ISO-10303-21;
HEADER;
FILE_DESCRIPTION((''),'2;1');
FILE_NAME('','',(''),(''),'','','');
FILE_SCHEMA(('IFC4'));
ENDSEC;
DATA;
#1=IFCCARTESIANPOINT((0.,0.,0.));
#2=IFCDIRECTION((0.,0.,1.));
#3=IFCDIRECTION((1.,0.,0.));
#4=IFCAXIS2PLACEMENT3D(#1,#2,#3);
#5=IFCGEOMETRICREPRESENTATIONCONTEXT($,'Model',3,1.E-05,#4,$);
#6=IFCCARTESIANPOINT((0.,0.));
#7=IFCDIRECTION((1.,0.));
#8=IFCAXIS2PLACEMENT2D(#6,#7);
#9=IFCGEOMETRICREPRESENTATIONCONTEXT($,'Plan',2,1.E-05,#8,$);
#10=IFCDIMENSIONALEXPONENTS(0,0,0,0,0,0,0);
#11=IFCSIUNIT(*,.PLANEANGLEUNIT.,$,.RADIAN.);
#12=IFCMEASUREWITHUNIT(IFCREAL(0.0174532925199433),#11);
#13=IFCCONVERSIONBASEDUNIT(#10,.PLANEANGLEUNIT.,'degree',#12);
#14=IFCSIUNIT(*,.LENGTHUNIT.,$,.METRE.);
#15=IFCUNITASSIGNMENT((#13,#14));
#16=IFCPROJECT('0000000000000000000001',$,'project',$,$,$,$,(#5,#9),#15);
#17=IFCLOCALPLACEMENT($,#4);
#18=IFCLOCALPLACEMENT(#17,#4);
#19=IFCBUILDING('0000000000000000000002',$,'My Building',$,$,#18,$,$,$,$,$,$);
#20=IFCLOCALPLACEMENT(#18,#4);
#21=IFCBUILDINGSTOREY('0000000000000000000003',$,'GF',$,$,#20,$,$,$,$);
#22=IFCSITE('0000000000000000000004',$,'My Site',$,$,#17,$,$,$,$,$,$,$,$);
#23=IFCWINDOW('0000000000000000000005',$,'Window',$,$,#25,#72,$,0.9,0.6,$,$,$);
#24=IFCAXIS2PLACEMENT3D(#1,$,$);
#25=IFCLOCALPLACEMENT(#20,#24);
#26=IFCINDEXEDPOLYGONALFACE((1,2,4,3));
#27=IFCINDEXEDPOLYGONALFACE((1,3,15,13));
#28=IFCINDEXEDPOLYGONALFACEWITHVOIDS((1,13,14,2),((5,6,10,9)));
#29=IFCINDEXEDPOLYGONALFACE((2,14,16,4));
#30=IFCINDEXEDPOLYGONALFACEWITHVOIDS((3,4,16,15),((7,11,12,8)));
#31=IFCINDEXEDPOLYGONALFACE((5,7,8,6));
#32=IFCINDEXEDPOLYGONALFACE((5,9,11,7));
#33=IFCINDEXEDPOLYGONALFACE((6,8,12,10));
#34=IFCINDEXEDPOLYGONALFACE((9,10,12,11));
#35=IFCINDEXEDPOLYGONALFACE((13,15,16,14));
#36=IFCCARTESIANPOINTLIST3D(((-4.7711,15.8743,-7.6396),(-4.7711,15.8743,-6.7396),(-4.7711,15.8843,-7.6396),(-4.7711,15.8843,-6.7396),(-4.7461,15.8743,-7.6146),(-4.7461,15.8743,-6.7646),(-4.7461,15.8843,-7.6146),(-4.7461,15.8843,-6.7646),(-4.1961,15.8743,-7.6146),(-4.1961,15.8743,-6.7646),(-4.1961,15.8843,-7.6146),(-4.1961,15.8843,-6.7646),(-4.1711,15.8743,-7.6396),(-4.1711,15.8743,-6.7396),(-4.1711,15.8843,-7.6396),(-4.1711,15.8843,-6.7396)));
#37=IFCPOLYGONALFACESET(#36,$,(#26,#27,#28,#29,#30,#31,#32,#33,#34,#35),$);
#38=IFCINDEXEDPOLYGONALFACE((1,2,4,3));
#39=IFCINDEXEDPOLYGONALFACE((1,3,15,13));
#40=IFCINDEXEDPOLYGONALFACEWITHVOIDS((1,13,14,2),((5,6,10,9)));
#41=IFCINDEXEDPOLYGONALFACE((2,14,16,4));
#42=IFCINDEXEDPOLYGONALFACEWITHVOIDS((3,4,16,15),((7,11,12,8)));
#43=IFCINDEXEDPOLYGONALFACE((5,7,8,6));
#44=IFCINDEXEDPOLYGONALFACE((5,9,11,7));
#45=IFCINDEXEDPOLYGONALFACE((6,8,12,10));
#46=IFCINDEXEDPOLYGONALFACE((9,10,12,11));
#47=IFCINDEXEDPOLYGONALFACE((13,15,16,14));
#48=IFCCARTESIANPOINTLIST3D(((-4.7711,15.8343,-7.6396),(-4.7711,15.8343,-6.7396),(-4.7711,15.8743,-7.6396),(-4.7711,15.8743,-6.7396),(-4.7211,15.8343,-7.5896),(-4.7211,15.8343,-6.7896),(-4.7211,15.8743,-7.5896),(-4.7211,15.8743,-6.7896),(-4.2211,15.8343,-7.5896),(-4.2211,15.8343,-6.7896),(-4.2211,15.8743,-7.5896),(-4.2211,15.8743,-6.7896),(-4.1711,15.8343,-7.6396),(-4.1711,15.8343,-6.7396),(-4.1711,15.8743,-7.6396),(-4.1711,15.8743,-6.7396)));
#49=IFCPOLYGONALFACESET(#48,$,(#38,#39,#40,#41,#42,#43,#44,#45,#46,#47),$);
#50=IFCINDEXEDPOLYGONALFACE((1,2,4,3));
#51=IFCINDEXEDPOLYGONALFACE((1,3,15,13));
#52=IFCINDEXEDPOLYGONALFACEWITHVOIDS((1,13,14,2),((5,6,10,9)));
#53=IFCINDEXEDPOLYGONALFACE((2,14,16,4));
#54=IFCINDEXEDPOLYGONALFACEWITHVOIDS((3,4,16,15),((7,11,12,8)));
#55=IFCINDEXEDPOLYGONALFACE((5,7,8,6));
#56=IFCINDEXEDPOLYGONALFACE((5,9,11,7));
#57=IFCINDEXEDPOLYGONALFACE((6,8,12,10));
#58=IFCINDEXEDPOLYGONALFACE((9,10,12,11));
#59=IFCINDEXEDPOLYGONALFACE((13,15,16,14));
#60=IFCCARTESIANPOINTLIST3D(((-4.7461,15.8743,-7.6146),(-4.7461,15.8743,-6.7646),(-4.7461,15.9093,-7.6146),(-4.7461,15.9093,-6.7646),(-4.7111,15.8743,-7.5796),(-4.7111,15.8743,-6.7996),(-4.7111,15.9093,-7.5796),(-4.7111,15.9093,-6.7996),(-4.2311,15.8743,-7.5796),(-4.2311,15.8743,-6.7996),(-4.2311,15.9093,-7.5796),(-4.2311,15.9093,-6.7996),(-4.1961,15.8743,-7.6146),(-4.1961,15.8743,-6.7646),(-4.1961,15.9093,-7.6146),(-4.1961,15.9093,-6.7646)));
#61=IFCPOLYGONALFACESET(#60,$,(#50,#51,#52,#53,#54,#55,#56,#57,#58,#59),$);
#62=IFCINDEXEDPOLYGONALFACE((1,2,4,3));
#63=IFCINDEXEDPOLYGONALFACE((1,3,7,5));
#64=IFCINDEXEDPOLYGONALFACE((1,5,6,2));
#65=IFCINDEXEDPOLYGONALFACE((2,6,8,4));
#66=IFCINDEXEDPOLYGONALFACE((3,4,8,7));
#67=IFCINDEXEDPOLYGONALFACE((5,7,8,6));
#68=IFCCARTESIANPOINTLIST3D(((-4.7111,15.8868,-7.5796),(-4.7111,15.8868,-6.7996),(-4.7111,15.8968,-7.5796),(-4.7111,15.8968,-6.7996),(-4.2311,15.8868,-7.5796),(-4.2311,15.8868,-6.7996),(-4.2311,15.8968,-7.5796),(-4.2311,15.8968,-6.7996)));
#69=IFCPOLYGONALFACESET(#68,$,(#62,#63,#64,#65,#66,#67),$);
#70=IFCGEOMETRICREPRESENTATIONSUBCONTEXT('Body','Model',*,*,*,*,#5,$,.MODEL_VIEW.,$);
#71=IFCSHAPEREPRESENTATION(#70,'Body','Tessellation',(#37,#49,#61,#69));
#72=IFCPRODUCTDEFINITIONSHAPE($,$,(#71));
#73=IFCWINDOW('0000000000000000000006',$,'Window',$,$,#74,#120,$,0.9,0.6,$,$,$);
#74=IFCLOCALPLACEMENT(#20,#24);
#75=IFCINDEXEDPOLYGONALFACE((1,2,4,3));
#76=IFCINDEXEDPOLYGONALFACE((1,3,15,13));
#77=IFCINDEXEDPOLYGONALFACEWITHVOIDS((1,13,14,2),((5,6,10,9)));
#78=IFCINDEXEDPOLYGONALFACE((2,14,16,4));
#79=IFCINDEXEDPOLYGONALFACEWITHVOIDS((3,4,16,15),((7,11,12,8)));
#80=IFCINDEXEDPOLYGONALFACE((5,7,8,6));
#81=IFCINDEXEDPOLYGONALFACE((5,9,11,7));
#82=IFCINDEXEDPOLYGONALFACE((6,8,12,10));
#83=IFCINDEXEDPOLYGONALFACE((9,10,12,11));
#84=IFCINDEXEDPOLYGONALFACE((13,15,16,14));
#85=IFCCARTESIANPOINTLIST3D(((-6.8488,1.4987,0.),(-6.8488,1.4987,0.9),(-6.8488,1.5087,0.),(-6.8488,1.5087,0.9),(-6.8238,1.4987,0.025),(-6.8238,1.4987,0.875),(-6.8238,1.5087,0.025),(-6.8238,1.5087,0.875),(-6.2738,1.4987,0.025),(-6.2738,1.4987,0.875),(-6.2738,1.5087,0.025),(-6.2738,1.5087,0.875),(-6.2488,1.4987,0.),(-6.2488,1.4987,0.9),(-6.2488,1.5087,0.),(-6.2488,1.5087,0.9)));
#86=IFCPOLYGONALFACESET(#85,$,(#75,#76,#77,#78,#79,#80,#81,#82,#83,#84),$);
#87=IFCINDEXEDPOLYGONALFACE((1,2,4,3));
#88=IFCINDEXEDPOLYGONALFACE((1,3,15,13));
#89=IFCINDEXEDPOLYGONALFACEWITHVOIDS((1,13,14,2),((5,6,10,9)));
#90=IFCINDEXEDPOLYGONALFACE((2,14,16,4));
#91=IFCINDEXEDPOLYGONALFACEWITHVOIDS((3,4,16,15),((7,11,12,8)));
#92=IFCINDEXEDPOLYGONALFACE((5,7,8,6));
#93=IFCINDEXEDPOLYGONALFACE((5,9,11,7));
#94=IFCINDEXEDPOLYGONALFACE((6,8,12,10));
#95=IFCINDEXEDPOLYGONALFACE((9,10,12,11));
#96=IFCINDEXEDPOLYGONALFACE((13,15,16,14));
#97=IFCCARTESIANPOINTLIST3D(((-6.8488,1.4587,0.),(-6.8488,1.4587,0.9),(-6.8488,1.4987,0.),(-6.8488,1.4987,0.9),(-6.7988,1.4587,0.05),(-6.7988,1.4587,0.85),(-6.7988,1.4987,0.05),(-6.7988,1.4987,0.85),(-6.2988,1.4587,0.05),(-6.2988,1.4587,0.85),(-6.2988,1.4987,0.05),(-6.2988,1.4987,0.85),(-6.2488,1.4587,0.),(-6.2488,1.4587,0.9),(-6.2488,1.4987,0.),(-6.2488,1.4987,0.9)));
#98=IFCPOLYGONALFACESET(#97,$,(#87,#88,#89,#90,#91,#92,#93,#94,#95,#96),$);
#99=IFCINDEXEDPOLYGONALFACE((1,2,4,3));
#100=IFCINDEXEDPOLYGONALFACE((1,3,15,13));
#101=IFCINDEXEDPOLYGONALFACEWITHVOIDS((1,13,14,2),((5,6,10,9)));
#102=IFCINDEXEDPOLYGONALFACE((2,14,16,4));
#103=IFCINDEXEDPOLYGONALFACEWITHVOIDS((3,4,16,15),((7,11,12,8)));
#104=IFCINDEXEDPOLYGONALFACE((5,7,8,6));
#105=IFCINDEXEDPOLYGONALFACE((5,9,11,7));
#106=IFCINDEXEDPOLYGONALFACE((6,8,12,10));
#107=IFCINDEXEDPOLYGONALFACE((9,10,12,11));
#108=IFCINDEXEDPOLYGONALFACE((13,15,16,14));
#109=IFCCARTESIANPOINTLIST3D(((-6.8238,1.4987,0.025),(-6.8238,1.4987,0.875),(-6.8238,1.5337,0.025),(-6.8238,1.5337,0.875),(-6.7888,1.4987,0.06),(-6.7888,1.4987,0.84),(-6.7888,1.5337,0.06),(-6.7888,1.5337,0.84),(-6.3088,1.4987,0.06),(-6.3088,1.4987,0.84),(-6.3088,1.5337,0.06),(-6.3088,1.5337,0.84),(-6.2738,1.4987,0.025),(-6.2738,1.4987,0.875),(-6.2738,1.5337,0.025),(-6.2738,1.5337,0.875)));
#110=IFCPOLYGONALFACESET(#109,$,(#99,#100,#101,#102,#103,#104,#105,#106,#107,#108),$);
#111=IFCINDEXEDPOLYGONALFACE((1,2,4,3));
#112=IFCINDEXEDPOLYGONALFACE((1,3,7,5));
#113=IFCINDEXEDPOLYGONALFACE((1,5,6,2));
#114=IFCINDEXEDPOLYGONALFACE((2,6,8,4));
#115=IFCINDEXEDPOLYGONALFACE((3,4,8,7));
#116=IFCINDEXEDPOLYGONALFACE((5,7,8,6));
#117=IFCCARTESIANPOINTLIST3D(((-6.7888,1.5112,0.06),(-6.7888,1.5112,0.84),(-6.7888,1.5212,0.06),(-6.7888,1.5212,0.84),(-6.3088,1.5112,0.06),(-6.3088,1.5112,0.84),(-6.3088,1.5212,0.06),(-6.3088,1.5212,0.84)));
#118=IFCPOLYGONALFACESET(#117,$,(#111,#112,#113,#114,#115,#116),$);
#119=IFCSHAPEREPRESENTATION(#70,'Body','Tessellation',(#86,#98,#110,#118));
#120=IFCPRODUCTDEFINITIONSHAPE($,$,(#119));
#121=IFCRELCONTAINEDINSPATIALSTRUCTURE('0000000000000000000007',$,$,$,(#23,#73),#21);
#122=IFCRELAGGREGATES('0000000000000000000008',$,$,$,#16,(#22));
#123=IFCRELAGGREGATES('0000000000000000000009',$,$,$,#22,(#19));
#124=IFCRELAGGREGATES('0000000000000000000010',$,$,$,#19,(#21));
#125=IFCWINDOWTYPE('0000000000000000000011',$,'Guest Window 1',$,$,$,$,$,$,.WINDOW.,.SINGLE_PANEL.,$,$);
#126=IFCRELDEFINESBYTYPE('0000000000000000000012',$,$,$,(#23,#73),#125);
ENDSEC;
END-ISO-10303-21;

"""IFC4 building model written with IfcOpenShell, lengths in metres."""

from ifc_helpers import new_model, entity, si_unit, converted_unit, frame, origin_with_axes, origin_2d_with_axis, place, context, subcontext, project, spatial, line, indexed_curve, outline, extrude, shape, source, transform, mapped, type_object, type_shapes, element, save


model = new_model("IFC4")

# Units and contexts
model_context = context("Model", 3, precision=1e-05, world=origin_with_axes())
plan_context = context("Plan", 2, precision=1e-05, world=origin_2d_with_axis())
body_context_1 = subcontext(model_context, "Body", "Model", "MODEL_VIEW")
body_context_2 = subcontext(plan_context, "Body", "Plan", "PLAN_VIEW")
ifc_project = project(units=[converted_unit("PLANEANGLEUNIT", "degree", entity("IfcReal", 0.0174532925199433), si_unit("PLANEANGLEUNIT", "RADIAN"), dimensions=[0, 0, 0, 0, 0, 0, 0]), si_unit("LENGTHUNIT", "METRE")], contexts=[model_context, plan_context])

# Site, building, storey
site_placement = place(None, origin_with_axes())
site = spatial("IfcSite", under=ifc_project, at=site_placement, Name="My Site")
building_placement = place(site_placement, origin_with_axes())
building = spatial("IfcBuilding", under=site, at=building_placement, Name="My Building")
storey_placement = place(building_placement, origin_with_axes())
storey = spatial("IfcBuildingStorey", under=building, at=storey_placement, Name="GF")

# Windows
window_type_1 = type_object("IfcWindowType", Name="Guest Window 1", PartitioningType="SINGLE_PANEL", PredefinedType="WINDOW")
shared_shape_1 = source(origin_with_axes(), body_context_1, "Body", "SweptSolid", [
    extrude(outline(indexed_curve([(0.0, 0.0), (0.6, 0.0), (0.6, 0.9), (0.0, 0.9)], segments=[line(1, 2, 3, 4, 1)]), holes=[indexed_curve([(0.025, 0.025), (0.575, 0.025), (0.575, 0.875), (0.025, 0.875)], segments=[line(1, 2, 3, 4, 1)])]), frame((0.0, 0.09, 0.0), z_axis=(0.0, -1.0, 0.0), x_axis=(1.0, 0.0, 0.0)), (0.0, 0.0, -1.0), 0.01),
    extrude(outline(indexed_curve([(0.0, 0.0), (0.6, 0.0), (0.6, 0.9), (0.0, 0.9)], segments=[line(1, 2, 3, 4, 1)]), holes=[indexed_curve([(0.05, 0.05), (0.55, 0.05), (0.55, 0.85), (0.05, 0.85)], segments=[line(1, 2, 3, 4, 1)])]), frame((0.0, 0.05, 0.0), z_axis=(0.0, -1.0, 0.0), x_axis=(1.0, 0.0, 0.0)), (0.0, 0.0, -1.0), 0.04),
    extrude(outline(indexed_curve([(0.0, 0.0), (0.55, 0.0), (0.55, 0.85), (0.0, 0.85)], segments=[line(1, 2, 3, 4, 1)]), holes=[indexed_curve([(0.035, 0.035), (0.515, 0.035), (0.515, 0.815), (0.035, 0.815)], segments=[line(1, 2, 3, 4, 1)])]), frame((0.025, 0.09, 0.025), z_axis=(0.0, -1.0, 0.0), x_axis=(1.0, 0.0, 0.0)), (0.0, 0.0, -1.0), 0.035),
    extrude(outline(indexed_curve([(0.035, 0.035), (0.515, 0.035), (0.515, 0.815), (0.035, 0.815)], segments=[line(1, 2, 3, 4, 1)])), frame((0.025, 0.1025, 0.025), z_axis=(0.0, -1.0, 0.0), x_axis=(1.0, 0.0, 0.0)), (0.0, 0.0, -1.0), 0.01),
])
shared_shape_2 = source(origin_with_axes(), body_context_2, "Body", "Curve2D", [
    entity("IfcIndexedPolyCurve", entity("IfcCartesianPointList2D", [[0.05, 0.05], [0.55, 0.05]])),
    entity("IfcIndexedPolyCurve", entity("IfcCartesianPointList2D", [[0.0, 0.1], [0.025, 0.1], [0.025, 0.09], [0.05, 0.09], [0.05, 0.05], [0.0, 0.05]]), [entity("IfcLineIndex", [1, 2, 3, 4, 5, 6, 1])]),
    entity("IfcIndexedPolyCurve", entity("IfcCartesianPointList2D", [[0.6, 0.1], [0.575, 0.1], [0.575, 0.09], [0.55, 0.09], [0.55, 0.05], [0.6, 0.05]]), [entity("IfcLineIndex", [1, 2, 3, 4, 5, 6, 1])]),
    entity("IfcIndexedPolyCurve", entity("IfcCartesianPointList2D", [[0.025, 0.09], [0.06, 0.09], [0.06, 0.125], [0.025, 0.125]]), [entity("IfcLineIndex", [1, 2, 3, 4, 1])]),
    entity("IfcIndexedPolyCurve", entity("IfcCartesianPointList2D", [[0.575, 0.09], [0.54, 0.09], [0.54, 0.125], [0.575, 0.125]]), [entity("IfcLineIndex", [1, 2, 3, 4, 1])]),
    entity("IfcIndexedPolyCurve", entity("IfcCartesianPointList2D", [[0.06, 0.09], [0.54, 0.09]])),
    entity("IfcIndexedPolyCurve", entity("IfcCartesianPointList2D", [[0.06, 0.125], [0.54, 0.125]])),
    entity("IfcIndexedPolyCurve", entity("IfcCartesianPointList2D", [[0.06, 0.1075], [0.54, 0.1075]])),
])
type_shapes(window_type_1, [shared_shape_1, shared_shape_2])
for number, where, z_axis, x_axis, name in (
    (1, (-4.7711, 15.7843, -7.6396), (0.0, 0.0, 1.0), (1.0, 0.0, 0.0), "Window"),
    (2, (-6.8488, 1.4087, 0.0), (0.0, 0.0, 1.0), (1.0, 0.0, 0.0), "Window"),
):
    element("IfcWindow", number, at=place(storey_placement, frame(where, z_axis=z_axis, x_axis=x_axis)), inside=storey, type_object=window_type_1, Name=name, OverallHeight=0.9, OverallWidth=0.6, shapes=[
        shape(body_context_1, "Body", "MappedRepresentation", [mapped(shared_shape_1, transform((0.0, 0.0, 0.0), x_axis=(1.0, 0.0, 0.0), y_axis=(0.0, 1.0, 0.0), z_axis=(0.0, 0.0, 1.0), scale=1.0))]),
        shape(body_context_2, "Body", "MappedRepresentation", [mapped(shared_shape_2, transform((0.0, 0.0, 0.0), x_axis=(1.0, 0.0, 0.0), y_axis=(0.0, 1.0, 0.0), z_axis=(0.0, 0.0, 1.0), scale=1.0))]),
    ])

save(model, "model.ifc")
